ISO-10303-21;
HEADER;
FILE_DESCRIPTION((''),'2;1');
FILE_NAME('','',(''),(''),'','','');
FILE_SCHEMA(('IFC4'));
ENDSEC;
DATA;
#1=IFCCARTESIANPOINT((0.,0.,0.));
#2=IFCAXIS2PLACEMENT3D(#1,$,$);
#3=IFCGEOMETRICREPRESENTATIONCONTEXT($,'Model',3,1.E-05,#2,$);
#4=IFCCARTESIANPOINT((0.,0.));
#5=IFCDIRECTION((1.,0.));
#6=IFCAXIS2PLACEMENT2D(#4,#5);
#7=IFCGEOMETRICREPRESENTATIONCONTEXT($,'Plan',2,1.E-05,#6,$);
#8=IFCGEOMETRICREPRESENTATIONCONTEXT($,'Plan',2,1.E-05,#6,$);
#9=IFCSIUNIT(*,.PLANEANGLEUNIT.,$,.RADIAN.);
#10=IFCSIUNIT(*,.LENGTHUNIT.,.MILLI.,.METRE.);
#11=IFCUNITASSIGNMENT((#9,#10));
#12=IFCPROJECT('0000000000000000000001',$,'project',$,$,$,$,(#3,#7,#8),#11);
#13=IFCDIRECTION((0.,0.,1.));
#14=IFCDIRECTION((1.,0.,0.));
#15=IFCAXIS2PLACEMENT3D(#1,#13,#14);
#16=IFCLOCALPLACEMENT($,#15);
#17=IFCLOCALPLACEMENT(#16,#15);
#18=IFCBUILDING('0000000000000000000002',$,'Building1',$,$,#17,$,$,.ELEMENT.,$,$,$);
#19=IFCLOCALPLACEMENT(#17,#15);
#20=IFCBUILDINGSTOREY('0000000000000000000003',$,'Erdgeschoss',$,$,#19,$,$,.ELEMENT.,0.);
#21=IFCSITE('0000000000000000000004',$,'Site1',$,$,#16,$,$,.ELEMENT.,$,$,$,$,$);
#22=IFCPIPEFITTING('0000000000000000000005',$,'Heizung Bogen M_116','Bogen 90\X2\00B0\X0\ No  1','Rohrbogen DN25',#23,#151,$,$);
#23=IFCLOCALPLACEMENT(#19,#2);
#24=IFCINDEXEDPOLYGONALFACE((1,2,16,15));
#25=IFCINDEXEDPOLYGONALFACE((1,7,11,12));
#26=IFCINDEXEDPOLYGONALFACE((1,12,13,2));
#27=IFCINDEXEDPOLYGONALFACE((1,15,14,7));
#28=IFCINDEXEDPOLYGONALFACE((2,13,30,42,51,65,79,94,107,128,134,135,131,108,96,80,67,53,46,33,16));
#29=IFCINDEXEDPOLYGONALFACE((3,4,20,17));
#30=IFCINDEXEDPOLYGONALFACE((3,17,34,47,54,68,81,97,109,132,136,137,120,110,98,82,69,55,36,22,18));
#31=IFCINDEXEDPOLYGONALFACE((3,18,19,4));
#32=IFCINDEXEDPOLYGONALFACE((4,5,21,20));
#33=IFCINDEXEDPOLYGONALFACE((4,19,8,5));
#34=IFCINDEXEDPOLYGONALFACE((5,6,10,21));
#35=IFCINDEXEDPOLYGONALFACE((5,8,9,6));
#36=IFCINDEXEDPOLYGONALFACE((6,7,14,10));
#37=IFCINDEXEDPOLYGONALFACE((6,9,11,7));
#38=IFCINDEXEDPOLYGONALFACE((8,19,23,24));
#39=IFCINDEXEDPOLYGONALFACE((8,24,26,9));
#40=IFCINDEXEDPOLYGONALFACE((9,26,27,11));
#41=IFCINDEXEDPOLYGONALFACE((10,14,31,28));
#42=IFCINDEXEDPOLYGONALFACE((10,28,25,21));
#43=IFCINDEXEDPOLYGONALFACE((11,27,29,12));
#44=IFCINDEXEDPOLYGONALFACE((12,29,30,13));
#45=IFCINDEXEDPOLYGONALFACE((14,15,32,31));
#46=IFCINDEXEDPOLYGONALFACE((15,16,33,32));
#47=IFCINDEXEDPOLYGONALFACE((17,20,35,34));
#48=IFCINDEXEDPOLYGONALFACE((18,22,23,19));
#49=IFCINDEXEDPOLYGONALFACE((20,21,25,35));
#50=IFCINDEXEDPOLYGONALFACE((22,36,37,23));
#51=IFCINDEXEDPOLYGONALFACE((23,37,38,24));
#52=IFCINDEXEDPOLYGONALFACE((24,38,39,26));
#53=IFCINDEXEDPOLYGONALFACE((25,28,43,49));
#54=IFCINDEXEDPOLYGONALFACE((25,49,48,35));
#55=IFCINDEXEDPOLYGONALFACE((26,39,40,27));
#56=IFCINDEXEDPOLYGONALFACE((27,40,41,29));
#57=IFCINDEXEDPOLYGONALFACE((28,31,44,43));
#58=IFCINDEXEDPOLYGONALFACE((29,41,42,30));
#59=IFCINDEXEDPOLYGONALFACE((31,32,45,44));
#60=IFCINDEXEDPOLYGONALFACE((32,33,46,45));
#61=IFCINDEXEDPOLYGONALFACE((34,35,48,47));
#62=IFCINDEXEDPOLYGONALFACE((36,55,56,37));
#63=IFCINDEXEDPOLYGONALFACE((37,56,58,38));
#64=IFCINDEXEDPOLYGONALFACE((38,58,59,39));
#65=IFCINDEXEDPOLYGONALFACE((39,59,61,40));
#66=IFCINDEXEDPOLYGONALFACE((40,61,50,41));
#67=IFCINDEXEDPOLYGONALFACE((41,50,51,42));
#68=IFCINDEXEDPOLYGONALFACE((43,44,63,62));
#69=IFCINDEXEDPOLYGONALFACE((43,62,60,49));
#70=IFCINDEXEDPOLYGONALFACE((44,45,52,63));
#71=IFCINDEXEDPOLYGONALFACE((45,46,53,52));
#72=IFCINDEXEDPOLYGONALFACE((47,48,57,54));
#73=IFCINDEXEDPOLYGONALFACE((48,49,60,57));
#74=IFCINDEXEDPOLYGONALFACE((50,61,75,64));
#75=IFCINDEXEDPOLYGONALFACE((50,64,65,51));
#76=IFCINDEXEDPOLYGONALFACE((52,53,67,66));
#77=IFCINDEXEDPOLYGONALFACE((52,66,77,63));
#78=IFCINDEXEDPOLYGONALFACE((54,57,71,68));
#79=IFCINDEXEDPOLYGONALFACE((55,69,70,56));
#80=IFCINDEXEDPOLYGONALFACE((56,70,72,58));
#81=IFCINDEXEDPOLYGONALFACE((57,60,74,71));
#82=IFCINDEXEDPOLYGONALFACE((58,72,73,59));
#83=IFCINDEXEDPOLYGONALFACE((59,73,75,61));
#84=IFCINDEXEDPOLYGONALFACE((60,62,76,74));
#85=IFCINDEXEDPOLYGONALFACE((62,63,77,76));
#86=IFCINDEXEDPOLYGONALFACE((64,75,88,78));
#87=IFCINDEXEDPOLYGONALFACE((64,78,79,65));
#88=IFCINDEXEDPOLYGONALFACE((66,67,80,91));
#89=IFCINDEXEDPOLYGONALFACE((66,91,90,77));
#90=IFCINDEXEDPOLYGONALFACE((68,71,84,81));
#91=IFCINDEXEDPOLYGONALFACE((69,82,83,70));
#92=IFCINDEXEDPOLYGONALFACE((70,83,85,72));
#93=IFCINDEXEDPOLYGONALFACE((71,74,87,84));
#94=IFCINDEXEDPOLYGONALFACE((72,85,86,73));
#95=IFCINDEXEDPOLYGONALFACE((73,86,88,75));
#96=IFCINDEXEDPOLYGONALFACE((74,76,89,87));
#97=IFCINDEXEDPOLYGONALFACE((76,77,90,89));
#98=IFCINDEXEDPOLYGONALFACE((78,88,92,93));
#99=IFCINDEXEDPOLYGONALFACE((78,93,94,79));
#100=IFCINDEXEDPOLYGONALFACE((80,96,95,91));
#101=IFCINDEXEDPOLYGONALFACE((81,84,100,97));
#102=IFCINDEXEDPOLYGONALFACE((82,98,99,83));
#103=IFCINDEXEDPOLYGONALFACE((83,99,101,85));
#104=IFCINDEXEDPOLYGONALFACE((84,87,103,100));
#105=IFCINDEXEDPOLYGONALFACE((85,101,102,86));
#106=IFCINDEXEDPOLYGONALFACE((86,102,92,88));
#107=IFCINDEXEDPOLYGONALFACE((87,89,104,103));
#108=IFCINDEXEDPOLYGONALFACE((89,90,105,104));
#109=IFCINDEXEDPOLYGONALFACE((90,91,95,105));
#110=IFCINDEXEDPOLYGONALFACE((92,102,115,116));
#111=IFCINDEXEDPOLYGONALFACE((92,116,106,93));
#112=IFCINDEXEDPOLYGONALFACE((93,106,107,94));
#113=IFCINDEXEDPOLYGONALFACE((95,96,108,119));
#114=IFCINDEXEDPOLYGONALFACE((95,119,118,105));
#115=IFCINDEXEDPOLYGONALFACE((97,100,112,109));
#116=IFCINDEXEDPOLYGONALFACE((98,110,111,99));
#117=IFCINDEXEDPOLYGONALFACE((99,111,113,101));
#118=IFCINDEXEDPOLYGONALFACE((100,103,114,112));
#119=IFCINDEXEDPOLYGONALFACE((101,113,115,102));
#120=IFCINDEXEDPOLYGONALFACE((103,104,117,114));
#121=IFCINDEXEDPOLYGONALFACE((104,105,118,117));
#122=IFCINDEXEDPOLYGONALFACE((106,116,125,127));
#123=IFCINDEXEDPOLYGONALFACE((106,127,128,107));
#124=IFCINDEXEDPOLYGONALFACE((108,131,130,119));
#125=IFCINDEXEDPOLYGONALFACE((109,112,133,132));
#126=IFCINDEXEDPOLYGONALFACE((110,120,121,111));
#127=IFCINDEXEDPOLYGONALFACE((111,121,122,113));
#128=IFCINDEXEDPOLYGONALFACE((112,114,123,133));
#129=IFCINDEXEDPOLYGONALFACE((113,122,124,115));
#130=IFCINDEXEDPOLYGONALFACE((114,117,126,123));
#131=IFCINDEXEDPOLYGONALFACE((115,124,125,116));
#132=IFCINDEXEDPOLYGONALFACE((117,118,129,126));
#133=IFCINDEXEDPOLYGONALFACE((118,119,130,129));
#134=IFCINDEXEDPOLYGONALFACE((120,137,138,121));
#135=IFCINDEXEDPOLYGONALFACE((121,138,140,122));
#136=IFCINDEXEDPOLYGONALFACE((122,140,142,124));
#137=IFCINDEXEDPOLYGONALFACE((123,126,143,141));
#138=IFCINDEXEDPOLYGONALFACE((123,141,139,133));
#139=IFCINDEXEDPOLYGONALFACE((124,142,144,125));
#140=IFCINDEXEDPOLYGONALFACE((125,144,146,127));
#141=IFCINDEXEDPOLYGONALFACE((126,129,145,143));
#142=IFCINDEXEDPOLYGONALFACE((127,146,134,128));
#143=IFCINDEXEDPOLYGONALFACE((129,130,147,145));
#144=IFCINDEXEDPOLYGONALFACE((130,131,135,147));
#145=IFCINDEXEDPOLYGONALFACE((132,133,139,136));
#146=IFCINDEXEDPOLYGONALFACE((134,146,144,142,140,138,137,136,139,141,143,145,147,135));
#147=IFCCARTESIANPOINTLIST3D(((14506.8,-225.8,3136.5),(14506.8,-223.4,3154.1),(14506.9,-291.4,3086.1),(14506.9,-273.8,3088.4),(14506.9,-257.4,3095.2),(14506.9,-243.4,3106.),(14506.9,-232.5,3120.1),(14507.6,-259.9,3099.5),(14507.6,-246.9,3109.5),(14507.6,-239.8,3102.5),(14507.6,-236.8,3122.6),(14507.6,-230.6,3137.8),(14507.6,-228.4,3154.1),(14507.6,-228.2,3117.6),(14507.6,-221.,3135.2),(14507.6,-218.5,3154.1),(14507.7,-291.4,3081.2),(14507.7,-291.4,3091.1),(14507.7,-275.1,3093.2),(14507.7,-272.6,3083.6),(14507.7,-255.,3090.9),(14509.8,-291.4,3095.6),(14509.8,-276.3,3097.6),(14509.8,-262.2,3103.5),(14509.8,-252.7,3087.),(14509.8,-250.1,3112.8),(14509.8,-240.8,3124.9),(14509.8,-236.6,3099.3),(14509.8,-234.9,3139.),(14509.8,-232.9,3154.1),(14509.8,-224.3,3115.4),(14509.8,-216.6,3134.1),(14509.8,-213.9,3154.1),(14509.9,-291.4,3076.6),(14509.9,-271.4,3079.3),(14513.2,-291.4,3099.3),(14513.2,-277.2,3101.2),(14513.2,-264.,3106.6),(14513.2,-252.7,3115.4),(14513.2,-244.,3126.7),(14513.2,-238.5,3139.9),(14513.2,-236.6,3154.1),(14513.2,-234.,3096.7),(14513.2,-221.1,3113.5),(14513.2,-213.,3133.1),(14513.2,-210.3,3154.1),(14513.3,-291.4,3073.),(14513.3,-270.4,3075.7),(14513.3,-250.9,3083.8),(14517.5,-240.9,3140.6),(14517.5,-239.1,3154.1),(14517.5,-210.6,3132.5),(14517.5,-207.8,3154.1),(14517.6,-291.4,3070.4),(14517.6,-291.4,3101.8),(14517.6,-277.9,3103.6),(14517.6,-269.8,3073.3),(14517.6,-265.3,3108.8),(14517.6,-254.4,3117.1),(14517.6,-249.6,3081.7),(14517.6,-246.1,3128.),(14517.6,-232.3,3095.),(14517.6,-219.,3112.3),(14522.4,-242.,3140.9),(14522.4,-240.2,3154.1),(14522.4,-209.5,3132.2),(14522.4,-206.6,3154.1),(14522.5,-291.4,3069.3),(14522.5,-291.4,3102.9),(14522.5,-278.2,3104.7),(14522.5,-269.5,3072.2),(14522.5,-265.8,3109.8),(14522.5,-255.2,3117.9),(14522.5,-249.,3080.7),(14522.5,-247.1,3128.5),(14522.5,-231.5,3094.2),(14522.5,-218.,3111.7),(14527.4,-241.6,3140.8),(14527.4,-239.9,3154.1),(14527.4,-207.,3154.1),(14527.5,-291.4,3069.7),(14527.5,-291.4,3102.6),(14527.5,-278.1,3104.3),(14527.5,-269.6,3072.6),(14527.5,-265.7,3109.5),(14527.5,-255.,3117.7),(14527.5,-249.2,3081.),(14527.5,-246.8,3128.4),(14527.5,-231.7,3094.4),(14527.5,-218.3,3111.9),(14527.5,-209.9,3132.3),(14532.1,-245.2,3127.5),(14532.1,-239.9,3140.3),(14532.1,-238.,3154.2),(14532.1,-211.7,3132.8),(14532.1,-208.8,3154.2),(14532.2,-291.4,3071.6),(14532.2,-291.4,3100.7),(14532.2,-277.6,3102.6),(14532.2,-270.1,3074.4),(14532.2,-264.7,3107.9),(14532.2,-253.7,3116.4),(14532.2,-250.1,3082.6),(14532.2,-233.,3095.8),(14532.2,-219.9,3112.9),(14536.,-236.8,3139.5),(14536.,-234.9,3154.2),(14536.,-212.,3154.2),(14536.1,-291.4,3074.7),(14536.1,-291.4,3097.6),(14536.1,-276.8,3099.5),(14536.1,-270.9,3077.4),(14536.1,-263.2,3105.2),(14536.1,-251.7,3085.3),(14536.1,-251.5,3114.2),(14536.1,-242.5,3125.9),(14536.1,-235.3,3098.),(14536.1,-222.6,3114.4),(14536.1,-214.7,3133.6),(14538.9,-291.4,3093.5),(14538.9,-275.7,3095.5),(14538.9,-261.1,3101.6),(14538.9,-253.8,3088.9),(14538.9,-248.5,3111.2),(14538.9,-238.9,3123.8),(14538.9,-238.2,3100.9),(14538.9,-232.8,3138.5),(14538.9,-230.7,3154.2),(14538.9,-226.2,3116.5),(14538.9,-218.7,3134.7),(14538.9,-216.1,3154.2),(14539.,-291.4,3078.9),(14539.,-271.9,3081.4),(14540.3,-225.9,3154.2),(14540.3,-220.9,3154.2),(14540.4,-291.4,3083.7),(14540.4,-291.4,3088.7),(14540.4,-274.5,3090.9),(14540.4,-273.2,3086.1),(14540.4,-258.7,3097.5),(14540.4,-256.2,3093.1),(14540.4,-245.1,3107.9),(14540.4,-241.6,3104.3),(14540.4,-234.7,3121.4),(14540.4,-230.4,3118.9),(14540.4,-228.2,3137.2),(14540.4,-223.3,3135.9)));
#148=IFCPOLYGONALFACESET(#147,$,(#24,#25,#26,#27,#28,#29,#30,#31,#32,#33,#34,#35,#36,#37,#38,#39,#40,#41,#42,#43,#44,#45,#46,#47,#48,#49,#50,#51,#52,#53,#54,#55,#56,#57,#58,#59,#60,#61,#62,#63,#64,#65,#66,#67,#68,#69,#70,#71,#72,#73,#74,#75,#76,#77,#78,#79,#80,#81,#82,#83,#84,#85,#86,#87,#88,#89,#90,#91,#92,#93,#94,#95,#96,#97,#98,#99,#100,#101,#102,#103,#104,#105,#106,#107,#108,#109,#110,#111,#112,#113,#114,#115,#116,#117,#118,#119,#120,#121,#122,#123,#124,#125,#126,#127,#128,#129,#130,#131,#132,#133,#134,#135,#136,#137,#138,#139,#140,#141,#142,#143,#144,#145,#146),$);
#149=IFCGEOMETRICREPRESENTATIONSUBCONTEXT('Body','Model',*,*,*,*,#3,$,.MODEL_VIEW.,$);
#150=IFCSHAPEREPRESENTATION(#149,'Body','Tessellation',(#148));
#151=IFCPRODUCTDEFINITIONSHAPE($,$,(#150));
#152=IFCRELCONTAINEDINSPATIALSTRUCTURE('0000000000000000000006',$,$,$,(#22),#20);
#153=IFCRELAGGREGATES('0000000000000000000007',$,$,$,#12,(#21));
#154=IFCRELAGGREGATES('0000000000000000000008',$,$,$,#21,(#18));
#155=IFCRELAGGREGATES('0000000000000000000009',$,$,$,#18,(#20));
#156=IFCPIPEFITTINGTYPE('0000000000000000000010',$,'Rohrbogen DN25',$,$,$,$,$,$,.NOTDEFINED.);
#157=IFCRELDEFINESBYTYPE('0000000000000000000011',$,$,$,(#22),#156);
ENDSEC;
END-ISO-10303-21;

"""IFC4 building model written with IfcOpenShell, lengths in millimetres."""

from ifc_helpers import new_model, entity, si_unit, frame, origin, origin_with_axes, origin_2d_with_axis, place, context, subcontext, project, spatial, source, transform, mapped, type_object, element, save


model = new_model("IFC4")

# Units and contexts
model_context = context("Model", 3, precision=1e-05, world=origin())
plan_context_1 = context("Plan", 2, precision=1e-05, world=origin_2d_with_axis())
plan_context_2 = context("Plan", 2, precision=1e-05, world=origin_2d_with_axis())
body_context = subcontext(model_context, "Body", "Model", "MODEL_VIEW")
ifc_project = project(units=[si_unit("PLANEANGLEUNIT", "RADIAN"), si_unit("LENGTHUNIT", "METRE", prefix="MILLI")], contexts=[model_context, plan_context_1, plan_context_2])

# Site, building, storey
site_placement = place(None, origin_with_axes())
site = spatial("IfcSite", under=ifc_project, at=site_placement, Name="Site1", CompositionType="ELEMENT")
building_placement = place(site_placement, origin_with_axes())
building = spatial("IfcBuilding", under=site, at=building_placement, Name="Building1", CompositionType="ELEMENT")
storey_placement = place(building_placement, origin_with_axes())
storey = spatial("IfcBuildingStorey", under=building, at=storey_placement, Name="Erdgeschoss", CompositionType="ELEMENT", Elevation=0.0)

# Pipe fitting
pipe_fitting_type = type_object("IfcPipeFittingType", Name="Rohrbogen DN25", PredefinedType="NOTDEFINED")
shared_shape_1 = source(origin_with_axes(), body_context, "Body", "SolidModel", [
    entity("IfcRevolvedAreaSolid", entity("IfcCircleProfileDef", "AREA", None, entity("IfcAxis2Placement2D", entity("IfcCartesianPoint", [0.0, 0.0]), entity("IfcDirection", [1.0, 0.0])), 16.9), entity("IfcAxis2Placement3D", entity("IfcCartesianPoint", [-42.4, 0.1, 25.6]), entity("IfcDirection", [1.0, 0.0, 0.0]), entity("IfcDirection", [0.0, -0.999997, 0.002343])), entity("IfcAxis1Placement", entity("IfcCartesianPoint", [0.0, 68.0, 0.0]), entity("IfcDirection", [-1.0, 0.0, 0.0])), 1.570796),
])
pipe_fitting_1_placement = place(storey_placement, frame((14523.7, -249.0, 3111.7), z_axis=(0.0, 0.0, 1.0), x_axis=(1.0, 0.0, 0.0)))
element("IfcPipeFitting", 1, at=pipe_fitting_1_placement, inside=storey, type_object=pipe_fitting_type, Name="Heizung Bogen M_116", Description="Bogen 90° No  1", ObjectType="Rohrbogen DN25", context=body_context, shape_type="MappedRepresentation", body=[
    mapped(shared_shape_1, transform((0.0, 0.0, 0.0), x_axis=(0.000001, 1.0, 0.0), y_axis=(1.0, -0.000001, -0.000979), z_axis=(-0.000979, 0.0, -1.0), scale=1.0)),
])

save(model, "model.ifc")
